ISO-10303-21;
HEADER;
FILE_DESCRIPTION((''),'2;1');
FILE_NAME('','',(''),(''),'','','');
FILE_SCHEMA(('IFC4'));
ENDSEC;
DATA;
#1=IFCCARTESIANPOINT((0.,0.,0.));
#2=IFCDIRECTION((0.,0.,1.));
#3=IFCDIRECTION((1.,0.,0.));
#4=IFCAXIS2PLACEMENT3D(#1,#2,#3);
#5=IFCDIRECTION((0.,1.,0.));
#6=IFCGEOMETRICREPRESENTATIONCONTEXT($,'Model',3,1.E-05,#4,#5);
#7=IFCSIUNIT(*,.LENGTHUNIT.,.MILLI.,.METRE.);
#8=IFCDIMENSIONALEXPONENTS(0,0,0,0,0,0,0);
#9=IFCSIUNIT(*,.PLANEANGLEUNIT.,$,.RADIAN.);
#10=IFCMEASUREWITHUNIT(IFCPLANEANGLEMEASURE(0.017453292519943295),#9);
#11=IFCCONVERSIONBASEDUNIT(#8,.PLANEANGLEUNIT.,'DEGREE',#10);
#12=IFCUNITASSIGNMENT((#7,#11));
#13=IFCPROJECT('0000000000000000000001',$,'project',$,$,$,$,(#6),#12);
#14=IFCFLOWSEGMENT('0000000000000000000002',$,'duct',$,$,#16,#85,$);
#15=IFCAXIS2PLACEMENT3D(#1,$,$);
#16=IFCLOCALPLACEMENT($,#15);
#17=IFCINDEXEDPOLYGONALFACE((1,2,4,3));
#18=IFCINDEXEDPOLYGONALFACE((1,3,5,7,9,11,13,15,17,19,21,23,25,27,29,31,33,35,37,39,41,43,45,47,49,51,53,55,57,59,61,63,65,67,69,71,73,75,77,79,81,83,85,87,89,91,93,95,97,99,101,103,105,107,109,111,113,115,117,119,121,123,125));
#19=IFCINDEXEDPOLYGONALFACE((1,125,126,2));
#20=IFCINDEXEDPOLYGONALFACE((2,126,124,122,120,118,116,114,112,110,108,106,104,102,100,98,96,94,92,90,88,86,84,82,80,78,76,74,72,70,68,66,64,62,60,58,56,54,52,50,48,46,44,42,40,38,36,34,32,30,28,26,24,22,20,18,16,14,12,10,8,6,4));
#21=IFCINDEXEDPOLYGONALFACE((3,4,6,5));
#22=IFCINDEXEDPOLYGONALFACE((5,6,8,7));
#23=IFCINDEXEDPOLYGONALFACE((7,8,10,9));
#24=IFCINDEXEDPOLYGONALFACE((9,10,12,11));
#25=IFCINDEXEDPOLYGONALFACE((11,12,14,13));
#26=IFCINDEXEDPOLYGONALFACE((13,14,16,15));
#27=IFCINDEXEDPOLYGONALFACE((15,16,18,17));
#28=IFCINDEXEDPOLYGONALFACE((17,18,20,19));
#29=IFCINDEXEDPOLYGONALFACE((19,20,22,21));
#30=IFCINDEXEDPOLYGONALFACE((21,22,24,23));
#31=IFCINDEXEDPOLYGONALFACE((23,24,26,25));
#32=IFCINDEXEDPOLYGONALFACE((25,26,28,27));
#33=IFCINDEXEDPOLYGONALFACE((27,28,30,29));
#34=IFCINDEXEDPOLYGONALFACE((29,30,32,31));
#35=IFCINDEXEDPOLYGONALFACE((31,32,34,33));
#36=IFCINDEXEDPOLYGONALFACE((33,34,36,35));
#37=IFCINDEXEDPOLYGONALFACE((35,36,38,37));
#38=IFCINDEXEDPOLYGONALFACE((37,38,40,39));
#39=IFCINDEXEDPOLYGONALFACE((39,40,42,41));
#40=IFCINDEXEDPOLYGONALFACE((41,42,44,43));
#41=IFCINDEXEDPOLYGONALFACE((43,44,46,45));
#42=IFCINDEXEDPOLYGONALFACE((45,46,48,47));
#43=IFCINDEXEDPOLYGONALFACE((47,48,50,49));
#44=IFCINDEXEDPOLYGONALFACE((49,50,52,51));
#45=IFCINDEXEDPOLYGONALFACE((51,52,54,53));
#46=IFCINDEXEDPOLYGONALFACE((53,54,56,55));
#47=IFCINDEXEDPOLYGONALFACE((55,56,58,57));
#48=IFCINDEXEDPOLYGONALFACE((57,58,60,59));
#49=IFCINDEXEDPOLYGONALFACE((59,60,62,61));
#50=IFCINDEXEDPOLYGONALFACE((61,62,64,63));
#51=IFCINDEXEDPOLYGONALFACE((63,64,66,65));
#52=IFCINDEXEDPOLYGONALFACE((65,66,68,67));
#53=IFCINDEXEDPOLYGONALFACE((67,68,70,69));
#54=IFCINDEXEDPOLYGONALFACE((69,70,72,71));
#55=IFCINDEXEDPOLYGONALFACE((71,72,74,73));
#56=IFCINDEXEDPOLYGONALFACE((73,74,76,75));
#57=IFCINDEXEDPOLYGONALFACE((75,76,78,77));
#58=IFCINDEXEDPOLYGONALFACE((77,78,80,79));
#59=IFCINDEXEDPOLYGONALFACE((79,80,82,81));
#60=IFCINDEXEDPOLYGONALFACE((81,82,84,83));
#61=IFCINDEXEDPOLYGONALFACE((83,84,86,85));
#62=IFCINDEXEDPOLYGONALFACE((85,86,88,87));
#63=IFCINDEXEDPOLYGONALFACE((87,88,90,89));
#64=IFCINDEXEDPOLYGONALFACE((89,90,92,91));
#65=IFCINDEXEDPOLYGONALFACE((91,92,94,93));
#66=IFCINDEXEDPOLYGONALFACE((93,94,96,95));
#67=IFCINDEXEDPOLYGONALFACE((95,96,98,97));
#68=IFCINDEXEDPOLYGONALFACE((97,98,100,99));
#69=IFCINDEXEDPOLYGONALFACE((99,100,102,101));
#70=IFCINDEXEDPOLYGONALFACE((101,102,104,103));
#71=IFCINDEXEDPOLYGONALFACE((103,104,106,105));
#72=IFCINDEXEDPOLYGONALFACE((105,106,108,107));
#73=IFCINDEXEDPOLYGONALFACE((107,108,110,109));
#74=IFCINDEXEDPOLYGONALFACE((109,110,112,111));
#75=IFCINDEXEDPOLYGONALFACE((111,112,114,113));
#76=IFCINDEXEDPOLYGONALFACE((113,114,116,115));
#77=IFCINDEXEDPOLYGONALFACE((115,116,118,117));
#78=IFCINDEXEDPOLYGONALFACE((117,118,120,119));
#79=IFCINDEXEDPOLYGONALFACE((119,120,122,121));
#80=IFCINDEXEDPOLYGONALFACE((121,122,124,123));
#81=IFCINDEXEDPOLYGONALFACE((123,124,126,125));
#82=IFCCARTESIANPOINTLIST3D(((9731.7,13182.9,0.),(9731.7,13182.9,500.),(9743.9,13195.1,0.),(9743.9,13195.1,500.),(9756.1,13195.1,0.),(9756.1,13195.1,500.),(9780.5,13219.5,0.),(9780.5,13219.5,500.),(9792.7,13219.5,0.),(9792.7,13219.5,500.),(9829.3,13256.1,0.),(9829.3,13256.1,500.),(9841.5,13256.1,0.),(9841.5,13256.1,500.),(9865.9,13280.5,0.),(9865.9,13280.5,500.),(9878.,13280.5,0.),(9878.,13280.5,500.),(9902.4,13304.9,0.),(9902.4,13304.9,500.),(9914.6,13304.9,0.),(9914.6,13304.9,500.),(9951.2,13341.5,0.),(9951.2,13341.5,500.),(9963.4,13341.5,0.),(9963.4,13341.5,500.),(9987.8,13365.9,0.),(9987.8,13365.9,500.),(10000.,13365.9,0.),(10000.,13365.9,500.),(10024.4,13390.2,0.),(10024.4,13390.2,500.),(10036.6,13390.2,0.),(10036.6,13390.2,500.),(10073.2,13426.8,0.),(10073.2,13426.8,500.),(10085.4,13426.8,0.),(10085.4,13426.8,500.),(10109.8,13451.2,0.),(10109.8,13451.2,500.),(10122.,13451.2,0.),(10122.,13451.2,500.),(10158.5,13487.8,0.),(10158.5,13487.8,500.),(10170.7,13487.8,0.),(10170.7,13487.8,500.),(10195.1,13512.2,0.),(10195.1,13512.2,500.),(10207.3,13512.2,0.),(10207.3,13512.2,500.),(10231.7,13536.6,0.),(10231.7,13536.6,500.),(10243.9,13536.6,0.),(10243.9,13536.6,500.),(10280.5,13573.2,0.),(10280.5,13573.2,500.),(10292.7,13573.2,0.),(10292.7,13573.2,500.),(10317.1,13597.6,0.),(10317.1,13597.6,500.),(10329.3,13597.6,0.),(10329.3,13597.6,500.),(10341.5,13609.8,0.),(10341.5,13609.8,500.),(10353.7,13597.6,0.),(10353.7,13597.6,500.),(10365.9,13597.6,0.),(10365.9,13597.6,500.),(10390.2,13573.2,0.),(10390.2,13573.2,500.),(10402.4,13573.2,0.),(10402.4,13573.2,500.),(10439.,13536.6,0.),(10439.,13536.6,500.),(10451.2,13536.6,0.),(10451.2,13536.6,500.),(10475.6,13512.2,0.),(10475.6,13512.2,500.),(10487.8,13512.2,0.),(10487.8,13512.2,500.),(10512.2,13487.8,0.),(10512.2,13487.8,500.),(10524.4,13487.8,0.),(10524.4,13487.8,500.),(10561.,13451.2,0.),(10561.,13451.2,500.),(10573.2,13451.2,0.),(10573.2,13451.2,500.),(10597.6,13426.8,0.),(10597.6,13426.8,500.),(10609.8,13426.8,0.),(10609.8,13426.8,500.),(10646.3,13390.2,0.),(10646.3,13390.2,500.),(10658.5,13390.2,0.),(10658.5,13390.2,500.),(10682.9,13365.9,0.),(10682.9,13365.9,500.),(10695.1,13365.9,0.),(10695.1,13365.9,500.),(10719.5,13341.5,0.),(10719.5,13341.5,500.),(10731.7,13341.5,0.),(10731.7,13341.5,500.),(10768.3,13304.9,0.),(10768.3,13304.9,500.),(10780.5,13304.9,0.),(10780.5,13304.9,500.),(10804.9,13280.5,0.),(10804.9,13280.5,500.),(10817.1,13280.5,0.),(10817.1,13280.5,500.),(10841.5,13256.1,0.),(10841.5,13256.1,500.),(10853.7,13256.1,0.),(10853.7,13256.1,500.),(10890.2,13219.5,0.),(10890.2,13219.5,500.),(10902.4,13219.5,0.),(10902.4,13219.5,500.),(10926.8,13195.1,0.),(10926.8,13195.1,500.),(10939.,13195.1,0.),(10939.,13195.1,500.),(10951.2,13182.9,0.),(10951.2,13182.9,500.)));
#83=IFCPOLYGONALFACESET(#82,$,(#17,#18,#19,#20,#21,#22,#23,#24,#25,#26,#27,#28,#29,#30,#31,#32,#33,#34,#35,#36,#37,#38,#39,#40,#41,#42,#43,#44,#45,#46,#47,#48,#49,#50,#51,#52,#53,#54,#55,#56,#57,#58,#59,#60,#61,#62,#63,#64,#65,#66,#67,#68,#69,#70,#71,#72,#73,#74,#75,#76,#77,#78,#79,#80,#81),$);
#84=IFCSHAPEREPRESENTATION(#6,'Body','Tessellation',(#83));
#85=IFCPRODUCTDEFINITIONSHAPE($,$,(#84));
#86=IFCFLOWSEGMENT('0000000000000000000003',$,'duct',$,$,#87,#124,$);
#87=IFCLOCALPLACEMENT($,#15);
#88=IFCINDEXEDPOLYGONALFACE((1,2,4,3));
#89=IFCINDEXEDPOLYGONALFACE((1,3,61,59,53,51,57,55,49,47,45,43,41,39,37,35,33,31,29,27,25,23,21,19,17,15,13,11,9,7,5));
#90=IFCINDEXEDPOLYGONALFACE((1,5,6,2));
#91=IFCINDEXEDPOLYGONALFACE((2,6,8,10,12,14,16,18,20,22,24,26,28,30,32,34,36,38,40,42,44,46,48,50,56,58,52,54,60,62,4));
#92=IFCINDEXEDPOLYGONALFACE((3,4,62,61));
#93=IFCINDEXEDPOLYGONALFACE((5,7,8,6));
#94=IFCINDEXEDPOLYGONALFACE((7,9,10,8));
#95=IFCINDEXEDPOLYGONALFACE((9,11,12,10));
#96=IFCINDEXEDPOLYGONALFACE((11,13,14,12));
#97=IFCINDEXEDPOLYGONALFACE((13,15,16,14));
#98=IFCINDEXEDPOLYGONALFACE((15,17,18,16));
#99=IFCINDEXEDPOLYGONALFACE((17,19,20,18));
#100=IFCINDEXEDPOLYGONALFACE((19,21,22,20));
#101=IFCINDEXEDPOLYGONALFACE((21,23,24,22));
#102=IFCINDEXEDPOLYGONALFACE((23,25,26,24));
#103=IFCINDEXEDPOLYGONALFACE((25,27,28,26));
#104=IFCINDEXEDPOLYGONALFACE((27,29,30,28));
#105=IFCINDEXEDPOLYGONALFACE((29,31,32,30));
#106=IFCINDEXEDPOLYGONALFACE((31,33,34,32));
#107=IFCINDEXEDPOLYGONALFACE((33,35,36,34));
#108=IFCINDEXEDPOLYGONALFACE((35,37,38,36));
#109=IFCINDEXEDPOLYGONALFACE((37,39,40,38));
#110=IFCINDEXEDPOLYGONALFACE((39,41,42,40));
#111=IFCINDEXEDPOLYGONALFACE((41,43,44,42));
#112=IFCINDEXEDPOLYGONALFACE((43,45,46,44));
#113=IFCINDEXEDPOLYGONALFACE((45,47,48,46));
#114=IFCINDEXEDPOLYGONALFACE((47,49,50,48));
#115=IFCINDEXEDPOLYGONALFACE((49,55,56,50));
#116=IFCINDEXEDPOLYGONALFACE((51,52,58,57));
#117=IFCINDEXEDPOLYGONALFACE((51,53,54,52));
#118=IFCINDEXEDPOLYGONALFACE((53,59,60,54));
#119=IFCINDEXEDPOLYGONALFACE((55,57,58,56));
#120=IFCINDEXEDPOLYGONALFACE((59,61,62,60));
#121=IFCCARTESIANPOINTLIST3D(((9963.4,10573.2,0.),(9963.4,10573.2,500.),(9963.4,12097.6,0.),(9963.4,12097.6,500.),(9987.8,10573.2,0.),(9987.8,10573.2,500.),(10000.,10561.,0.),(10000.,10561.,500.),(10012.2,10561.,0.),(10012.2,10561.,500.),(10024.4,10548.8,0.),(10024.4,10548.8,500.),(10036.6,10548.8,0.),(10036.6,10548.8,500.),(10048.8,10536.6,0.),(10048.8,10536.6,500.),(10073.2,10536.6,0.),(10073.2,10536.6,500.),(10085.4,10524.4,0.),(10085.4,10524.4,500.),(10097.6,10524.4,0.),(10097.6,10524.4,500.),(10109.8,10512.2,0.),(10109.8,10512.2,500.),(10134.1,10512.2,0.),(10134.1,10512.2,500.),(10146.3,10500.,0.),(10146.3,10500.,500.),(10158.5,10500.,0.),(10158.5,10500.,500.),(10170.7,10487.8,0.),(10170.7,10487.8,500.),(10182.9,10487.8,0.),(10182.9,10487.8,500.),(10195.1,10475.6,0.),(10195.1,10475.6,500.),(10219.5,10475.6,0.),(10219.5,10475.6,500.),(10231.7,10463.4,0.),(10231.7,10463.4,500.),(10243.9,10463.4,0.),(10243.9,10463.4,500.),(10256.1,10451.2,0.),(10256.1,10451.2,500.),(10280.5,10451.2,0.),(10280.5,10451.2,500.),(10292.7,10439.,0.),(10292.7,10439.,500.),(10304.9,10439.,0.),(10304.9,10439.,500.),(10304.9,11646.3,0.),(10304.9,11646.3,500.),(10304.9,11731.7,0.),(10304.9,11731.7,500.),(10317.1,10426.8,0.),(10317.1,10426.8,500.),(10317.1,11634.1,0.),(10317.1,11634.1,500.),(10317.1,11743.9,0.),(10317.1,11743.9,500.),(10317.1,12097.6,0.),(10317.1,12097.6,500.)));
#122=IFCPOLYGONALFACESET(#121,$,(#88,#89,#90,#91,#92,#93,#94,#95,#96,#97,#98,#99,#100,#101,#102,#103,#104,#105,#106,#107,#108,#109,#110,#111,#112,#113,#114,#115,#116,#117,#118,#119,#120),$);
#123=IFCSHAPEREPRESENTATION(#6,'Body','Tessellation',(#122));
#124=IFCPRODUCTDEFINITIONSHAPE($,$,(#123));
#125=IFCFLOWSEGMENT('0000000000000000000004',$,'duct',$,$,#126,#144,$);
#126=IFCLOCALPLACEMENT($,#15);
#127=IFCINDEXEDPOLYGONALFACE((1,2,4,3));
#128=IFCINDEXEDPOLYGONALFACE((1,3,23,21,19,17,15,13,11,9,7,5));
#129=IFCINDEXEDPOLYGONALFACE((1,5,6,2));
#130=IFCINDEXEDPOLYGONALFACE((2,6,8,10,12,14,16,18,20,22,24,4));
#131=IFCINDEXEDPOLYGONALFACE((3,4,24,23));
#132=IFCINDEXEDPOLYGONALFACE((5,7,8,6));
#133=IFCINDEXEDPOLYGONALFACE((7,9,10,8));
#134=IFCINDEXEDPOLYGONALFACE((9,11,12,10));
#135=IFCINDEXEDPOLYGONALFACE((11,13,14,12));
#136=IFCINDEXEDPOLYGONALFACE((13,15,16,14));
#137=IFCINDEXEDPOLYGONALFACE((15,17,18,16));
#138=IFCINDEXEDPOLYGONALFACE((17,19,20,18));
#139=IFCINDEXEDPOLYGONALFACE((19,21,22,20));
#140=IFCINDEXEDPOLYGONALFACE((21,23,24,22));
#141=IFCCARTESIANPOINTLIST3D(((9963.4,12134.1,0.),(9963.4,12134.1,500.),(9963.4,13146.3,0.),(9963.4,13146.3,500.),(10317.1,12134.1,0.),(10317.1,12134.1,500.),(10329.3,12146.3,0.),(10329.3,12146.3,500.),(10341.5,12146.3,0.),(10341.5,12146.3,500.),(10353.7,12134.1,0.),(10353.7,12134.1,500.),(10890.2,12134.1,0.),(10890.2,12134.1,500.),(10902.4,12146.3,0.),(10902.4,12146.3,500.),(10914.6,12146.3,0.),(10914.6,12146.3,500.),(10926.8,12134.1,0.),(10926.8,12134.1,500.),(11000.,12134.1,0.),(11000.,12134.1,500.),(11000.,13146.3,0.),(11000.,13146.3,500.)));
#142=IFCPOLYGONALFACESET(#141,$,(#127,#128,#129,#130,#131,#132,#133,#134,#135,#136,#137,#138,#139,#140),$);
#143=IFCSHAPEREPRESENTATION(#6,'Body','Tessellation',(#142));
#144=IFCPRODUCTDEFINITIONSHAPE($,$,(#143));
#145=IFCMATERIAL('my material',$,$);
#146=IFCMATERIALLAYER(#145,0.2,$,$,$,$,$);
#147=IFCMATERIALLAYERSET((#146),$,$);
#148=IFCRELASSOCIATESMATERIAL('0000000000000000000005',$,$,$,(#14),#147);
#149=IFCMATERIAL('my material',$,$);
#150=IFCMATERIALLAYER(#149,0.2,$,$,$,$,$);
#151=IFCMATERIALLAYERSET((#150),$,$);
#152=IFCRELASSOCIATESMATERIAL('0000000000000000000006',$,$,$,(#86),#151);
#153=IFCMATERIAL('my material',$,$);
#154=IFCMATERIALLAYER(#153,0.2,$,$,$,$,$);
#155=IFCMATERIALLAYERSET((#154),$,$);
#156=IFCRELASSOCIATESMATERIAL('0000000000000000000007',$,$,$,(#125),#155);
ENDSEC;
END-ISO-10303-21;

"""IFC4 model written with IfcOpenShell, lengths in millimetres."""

from ifc_helpers import new_model, entity, si_unit, converted_unit, direction, origin_with_axes, place, context, project, polyline, outline, extrude, material, layer, layer_set, layer_usage, element, save


model = new_model("IFC4")

# Units and contexts
model_context = context("Model", 3, precision=1e-05, world=origin_with_axes(), true_north=direction((0.0, 1.0, 0.0)))
ifc_project = project(units=[si_unit("LENGTHUNIT", "METRE", prefix="MILLI"), converted_unit("PLANEANGLEUNIT", "DEGREE", entity("IfcPlaneAngleMeasure", 0.017453292519943295), si_unit("PLANEANGLEUNIT", "RADIAN"), dimensions=[0, 0, 0, 0, 0, 0, 0])], contexts=[model_context])

# Flow segments
ifc_material_1 = material(Name="my material")
ifc_layer_1 = layer(ifc_material_1, 0.2)
ifc_layer_set_1 = layer_set([ifc_layer_1])
ifc_layer_usage_1 = layer_usage(ifc_layer_set_1, "AXIS2", "POSITIVE", -0.1)
flow_segment_1_placement = place(None, origin_with_axes())
element("IfcFlowSegment", 1, at=flow_segment_1_placement, material=ifc_layer_usage_1, Name="duct", context=model_context, shape_type="SweptSolid", body=[
    extrude(outline(polyline([(9731.7, 13182.9), (10951.2, 13182.9), (10939.0, 13195.1), (10926.8, 13195.1), (10902.4, 13219.5), (10890.2, 13219.5), (10853.7, 13256.1), (10841.5, 13256.1), (10817.1, 13280.5), (10804.9, 13280.5), (10780.5, 13304.9), (10768.3, 13304.9), (10731.7, 13341.5), (10719.5, 13341.5), (10695.1, 13365.9), (10682.9, 13365.9), (10658.5, 13390.2), (10646.3, 13390.2), (10609.8, 13426.8), (10597.6, 13426.8), (10573.2, 13451.2), (10561.0, 13451.2), (10524.4, 13487.8), (10512.2, 13487.8), (10487.8, 13512.2), (10475.6, 13512.2), (10451.2, 13536.6), (10439.0, 13536.6), (10402.4, 13573.2), (10390.2, 13573.2), (10365.9, 13597.6), (10353.7, 13597.6), (10341.5, 13609.8), (10329.3, 13597.6), (10317.1, 13597.6), (10292.7, 13573.2), (10280.5, 13573.2), (10243.9, 13536.6), (10231.7, 13536.6), (10207.3, 13512.2), (10195.1, 13512.2), (10170.7, 13487.8), (10158.5, 13487.8), (10122.0, 13451.2), (10109.8, 13451.2), (10085.4, 13426.8), (10073.2, 13426.8), (10036.6, 13390.2), (10024.4, 13390.2), (10000.0, 13365.9), (9987.8, 13365.9), (9963.4, 13341.5), (9951.2, 13341.5), (9914.6, 13304.9), (9902.4, 13304.9), (9878.0, 13280.5), (9865.9, 13280.5), (9841.5, 13256.1), (9829.3, 13256.1), (9792.7, 13219.5), (9780.5, 13219.5), (9756.1, 13195.1), (9743.9, 13195.1), (9731.7, 13182.9)])), origin_with_axes(), (0.0, 0.0, 1.0), 500.0),
])
ifc_material_2 = material(Name="my material")
ifc_layer_2 = layer(ifc_material_2, 0.2)
ifc_layer_set_2 = layer_set([ifc_layer_2])
ifc_layer_usage_2 = layer_usage(ifc_layer_set_2, "AXIS2", "POSITIVE", -0.1)
flow_segment_2_placement = place(None, origin_with_axes())
element("IfcFlowSegment", 2, at=flow_segment_2_placement, material=ifc_layer_usage_2, Name="duct", context=model_context, shape_type="SweptSolid", body=[
    extrude(outline(polyline([(9963.4, 10573.2), (9987.8, 10573.2), (10000.0, 10561.0), (10012.2, 10561.0), (10024.4, 10548.8), (10036.6, 10548.8), (10048.8, 10536.6), (10073.2, 10536.6), (10085.4, 10524.4), (10097.6, 10524.4), (10109.8, 10512.2), (10134.1, 10512.2), (10146.3, 10500.0), (10158.5, 10500.0), (10170.7, 10487.8), (10182.9, 10487.8), (10195.1, 10475.6), (10219.5, 10475.6), (10231.7, 10463.4), (10243.9, 10463.4), (10256.1, 10451.2), (10280.5, 10451.2), (10292.7, 10439.0), (10304.9, 10439.0), (10317.1, 10426.8), (10317.1, 11634.1), (10304.9, 11646.3), (10304.9, 11731.7), (10317.1, 11743.9), (10317.1, 12097.6), (9963.4, 12097.6), (9963.4, 10573.2)])), origin_with_axes(), (0.0, 0.0, 1.0), 500.0),
])
ifc_material_3 = material(Name="my material")
ifc_layer_3 = layer(ifc_material_3, 0.2)
ifc_layer_set_3 = layer_set([ifc_layer_3])
ifc_layer_usage_3 = layer_usage(ifc_layer_set_3, "AXIS2", "POSITIVE", -0.1)
flow_segment_3_placement = place(None, origin_with_axes())
element("IfcFlowSegment", 3, at=flow_segment_3_placement, material=ifc_layer_usage_3, Name="duct", context=model_context, shape_type="SweptSolid", body=[
    extrude(outline(polyline([(9963.4, 12134.1), (10317.1, 12134.1), (10329.3, 12146.3), (10341.5, 12146.3), (10353.7, 12134.1), (10890.2, 12134.1), (10902.4, 12146.3), (10914.6, 12146.3), (10926.8, 12134.1), (11000.0, 12134.1), (11000.0, 13146.3), (9963.4, 13146.3), (9963.4, 12134.1)])), origin_with_axes(), (0.0, 0.0, 1.0), 500.0),
])

save(model, "model.ifc")
